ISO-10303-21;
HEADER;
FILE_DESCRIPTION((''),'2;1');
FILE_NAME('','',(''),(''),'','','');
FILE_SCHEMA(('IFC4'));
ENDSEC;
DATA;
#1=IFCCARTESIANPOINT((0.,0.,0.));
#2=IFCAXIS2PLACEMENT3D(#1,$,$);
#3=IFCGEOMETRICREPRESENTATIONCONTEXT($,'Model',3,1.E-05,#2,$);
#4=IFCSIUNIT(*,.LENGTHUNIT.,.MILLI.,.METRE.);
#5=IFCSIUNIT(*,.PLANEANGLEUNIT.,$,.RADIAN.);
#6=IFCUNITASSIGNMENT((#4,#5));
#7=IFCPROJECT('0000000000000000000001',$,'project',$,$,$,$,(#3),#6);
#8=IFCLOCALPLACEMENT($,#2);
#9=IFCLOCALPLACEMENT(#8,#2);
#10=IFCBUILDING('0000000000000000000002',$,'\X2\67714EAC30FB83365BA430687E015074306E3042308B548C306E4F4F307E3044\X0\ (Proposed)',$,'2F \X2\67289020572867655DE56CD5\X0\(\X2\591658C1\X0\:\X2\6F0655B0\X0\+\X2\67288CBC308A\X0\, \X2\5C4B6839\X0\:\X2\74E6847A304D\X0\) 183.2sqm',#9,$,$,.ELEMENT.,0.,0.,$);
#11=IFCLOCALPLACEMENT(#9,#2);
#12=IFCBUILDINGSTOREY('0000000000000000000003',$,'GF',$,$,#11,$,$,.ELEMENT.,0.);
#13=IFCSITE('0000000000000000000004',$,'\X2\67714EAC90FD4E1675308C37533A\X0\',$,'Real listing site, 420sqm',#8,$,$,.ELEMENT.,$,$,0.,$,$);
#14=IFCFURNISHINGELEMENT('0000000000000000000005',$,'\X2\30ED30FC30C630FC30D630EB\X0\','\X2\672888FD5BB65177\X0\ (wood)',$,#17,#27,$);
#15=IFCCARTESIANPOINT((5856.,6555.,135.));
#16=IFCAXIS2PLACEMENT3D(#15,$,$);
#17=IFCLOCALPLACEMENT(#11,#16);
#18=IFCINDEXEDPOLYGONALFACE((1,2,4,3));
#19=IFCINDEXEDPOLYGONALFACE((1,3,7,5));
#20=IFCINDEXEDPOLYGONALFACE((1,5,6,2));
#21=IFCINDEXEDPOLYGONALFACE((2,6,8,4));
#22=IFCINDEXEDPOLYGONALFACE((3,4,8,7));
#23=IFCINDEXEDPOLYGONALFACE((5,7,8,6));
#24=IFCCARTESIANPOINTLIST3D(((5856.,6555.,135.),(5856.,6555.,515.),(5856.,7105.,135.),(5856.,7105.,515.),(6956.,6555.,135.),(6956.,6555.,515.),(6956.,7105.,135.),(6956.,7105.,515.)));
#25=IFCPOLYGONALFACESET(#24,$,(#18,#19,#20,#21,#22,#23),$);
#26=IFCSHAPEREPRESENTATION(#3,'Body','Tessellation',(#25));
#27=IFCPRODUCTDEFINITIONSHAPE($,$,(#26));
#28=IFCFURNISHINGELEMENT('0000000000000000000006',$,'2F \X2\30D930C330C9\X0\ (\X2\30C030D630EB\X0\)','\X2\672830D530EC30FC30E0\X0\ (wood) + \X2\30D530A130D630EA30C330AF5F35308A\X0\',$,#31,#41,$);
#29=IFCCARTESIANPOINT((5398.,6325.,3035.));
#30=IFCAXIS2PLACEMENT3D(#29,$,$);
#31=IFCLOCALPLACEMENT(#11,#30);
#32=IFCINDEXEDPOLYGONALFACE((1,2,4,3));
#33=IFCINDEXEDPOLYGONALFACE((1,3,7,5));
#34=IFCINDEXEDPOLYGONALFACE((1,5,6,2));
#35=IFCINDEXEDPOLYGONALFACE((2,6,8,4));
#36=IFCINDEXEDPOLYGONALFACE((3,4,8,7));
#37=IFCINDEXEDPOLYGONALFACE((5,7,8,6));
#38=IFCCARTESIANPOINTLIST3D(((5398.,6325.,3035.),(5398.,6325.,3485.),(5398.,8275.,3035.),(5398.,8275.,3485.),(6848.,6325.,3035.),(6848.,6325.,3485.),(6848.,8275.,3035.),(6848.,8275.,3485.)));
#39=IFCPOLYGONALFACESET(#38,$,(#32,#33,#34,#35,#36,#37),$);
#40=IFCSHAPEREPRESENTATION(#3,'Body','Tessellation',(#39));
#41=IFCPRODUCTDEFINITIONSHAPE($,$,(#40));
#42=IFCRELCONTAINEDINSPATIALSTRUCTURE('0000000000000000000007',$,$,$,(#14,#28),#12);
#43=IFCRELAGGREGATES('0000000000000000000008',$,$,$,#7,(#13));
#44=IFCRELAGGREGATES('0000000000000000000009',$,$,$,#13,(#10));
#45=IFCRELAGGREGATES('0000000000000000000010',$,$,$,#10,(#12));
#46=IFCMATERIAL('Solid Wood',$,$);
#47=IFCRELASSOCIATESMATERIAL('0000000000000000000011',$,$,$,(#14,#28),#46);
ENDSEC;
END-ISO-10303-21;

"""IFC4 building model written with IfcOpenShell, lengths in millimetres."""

from ifc_helpers import new_model, si_unit, frame, frame_2d, origin, place, context, project, spatial, rectangle, extrude, material, element, save


model = new_model("IFC4")

# Units and contexts
model_context = context("Model", 3, precision=1e-05, world=origin())
ifc_project = project(units=[si_unit("LENGTHUNIT", "METRE", prefix="MILLI"), si_unit("PLANEANGLEUNIT", "RADIAN")], contexts=[model_context])

# Site, building, storey
site_placement = place(None, origin())
site = spatial("IfcSite", under=ifc_project, at=site_placement, Name="東京都世田谷区", ObjectType="Real listing site, 420sqm", CompositionType="ELEMENT", RefElevation=0.0)
building_placement = place(site_placement, origin())
building = spatial("IfcBuilding", under=site, at=building_placement, Name="東京・茶室と縁側のある和の住まい (Proposed)", ObjectType="2F 木造在来工法(外壁:漆喰+木貼り, 屋根:瓦葺き) 183.2sqm", CompositionType="ELEMENT", ElevationOfRefHeight=0.0, ElevationOfTerrain=0.0)
storey_placement = place(building_placement, origin())
storey = spatial("IfcBuildingStorey", under=building, at=storey_placement, Name="GF", CompositionType="ELEMENT", Elevation=0.0)

# Shared definitions
ifc_material_1 = material(Name="Solid Wood")

# Furnishing elements
furnishing_1_placement = place(storey_placement, frame((5856.0, 6555.0, 135.0)))
element("IfcFurnishingElement", 1, at=furnishing_1_placement, inside=storey, material=ifc_material_1, Name="ローテーブル", Description="木製家具 (wood)", context=model_context, shape_type="SweptSolid", body=[
    extrude(rectangle(XDim=1100.0, YDim=550.0, at=frame_2d((550.0, 275.0))), frame((5856.0, 6555.0, 135.0)), (0.0, 0.0, 1.0), 380.0),
])
furnishing_2_placement = place(storey_placement, frame((5398.0, 6325.0, 3035.0)))
element("IfcFurnishingElement", 2, at=furnishing_2_placement, inside=storey, material=ifc_material_1, Name="2F ベッド (ダブル)", Description="木フレーム (wood) + ファブリック張り", context=model_context, shape_type="SweptSolid", body=[
    extrude(rectangle(XDim=1450.0, YDim=1950.0, at=frame_2d((725.0, 975.0))), frame((5398.0, 6325.0, 3035.0)), (0.0, 0.0, 1.0), 450.0),
])

save(model, "model.ifc")
